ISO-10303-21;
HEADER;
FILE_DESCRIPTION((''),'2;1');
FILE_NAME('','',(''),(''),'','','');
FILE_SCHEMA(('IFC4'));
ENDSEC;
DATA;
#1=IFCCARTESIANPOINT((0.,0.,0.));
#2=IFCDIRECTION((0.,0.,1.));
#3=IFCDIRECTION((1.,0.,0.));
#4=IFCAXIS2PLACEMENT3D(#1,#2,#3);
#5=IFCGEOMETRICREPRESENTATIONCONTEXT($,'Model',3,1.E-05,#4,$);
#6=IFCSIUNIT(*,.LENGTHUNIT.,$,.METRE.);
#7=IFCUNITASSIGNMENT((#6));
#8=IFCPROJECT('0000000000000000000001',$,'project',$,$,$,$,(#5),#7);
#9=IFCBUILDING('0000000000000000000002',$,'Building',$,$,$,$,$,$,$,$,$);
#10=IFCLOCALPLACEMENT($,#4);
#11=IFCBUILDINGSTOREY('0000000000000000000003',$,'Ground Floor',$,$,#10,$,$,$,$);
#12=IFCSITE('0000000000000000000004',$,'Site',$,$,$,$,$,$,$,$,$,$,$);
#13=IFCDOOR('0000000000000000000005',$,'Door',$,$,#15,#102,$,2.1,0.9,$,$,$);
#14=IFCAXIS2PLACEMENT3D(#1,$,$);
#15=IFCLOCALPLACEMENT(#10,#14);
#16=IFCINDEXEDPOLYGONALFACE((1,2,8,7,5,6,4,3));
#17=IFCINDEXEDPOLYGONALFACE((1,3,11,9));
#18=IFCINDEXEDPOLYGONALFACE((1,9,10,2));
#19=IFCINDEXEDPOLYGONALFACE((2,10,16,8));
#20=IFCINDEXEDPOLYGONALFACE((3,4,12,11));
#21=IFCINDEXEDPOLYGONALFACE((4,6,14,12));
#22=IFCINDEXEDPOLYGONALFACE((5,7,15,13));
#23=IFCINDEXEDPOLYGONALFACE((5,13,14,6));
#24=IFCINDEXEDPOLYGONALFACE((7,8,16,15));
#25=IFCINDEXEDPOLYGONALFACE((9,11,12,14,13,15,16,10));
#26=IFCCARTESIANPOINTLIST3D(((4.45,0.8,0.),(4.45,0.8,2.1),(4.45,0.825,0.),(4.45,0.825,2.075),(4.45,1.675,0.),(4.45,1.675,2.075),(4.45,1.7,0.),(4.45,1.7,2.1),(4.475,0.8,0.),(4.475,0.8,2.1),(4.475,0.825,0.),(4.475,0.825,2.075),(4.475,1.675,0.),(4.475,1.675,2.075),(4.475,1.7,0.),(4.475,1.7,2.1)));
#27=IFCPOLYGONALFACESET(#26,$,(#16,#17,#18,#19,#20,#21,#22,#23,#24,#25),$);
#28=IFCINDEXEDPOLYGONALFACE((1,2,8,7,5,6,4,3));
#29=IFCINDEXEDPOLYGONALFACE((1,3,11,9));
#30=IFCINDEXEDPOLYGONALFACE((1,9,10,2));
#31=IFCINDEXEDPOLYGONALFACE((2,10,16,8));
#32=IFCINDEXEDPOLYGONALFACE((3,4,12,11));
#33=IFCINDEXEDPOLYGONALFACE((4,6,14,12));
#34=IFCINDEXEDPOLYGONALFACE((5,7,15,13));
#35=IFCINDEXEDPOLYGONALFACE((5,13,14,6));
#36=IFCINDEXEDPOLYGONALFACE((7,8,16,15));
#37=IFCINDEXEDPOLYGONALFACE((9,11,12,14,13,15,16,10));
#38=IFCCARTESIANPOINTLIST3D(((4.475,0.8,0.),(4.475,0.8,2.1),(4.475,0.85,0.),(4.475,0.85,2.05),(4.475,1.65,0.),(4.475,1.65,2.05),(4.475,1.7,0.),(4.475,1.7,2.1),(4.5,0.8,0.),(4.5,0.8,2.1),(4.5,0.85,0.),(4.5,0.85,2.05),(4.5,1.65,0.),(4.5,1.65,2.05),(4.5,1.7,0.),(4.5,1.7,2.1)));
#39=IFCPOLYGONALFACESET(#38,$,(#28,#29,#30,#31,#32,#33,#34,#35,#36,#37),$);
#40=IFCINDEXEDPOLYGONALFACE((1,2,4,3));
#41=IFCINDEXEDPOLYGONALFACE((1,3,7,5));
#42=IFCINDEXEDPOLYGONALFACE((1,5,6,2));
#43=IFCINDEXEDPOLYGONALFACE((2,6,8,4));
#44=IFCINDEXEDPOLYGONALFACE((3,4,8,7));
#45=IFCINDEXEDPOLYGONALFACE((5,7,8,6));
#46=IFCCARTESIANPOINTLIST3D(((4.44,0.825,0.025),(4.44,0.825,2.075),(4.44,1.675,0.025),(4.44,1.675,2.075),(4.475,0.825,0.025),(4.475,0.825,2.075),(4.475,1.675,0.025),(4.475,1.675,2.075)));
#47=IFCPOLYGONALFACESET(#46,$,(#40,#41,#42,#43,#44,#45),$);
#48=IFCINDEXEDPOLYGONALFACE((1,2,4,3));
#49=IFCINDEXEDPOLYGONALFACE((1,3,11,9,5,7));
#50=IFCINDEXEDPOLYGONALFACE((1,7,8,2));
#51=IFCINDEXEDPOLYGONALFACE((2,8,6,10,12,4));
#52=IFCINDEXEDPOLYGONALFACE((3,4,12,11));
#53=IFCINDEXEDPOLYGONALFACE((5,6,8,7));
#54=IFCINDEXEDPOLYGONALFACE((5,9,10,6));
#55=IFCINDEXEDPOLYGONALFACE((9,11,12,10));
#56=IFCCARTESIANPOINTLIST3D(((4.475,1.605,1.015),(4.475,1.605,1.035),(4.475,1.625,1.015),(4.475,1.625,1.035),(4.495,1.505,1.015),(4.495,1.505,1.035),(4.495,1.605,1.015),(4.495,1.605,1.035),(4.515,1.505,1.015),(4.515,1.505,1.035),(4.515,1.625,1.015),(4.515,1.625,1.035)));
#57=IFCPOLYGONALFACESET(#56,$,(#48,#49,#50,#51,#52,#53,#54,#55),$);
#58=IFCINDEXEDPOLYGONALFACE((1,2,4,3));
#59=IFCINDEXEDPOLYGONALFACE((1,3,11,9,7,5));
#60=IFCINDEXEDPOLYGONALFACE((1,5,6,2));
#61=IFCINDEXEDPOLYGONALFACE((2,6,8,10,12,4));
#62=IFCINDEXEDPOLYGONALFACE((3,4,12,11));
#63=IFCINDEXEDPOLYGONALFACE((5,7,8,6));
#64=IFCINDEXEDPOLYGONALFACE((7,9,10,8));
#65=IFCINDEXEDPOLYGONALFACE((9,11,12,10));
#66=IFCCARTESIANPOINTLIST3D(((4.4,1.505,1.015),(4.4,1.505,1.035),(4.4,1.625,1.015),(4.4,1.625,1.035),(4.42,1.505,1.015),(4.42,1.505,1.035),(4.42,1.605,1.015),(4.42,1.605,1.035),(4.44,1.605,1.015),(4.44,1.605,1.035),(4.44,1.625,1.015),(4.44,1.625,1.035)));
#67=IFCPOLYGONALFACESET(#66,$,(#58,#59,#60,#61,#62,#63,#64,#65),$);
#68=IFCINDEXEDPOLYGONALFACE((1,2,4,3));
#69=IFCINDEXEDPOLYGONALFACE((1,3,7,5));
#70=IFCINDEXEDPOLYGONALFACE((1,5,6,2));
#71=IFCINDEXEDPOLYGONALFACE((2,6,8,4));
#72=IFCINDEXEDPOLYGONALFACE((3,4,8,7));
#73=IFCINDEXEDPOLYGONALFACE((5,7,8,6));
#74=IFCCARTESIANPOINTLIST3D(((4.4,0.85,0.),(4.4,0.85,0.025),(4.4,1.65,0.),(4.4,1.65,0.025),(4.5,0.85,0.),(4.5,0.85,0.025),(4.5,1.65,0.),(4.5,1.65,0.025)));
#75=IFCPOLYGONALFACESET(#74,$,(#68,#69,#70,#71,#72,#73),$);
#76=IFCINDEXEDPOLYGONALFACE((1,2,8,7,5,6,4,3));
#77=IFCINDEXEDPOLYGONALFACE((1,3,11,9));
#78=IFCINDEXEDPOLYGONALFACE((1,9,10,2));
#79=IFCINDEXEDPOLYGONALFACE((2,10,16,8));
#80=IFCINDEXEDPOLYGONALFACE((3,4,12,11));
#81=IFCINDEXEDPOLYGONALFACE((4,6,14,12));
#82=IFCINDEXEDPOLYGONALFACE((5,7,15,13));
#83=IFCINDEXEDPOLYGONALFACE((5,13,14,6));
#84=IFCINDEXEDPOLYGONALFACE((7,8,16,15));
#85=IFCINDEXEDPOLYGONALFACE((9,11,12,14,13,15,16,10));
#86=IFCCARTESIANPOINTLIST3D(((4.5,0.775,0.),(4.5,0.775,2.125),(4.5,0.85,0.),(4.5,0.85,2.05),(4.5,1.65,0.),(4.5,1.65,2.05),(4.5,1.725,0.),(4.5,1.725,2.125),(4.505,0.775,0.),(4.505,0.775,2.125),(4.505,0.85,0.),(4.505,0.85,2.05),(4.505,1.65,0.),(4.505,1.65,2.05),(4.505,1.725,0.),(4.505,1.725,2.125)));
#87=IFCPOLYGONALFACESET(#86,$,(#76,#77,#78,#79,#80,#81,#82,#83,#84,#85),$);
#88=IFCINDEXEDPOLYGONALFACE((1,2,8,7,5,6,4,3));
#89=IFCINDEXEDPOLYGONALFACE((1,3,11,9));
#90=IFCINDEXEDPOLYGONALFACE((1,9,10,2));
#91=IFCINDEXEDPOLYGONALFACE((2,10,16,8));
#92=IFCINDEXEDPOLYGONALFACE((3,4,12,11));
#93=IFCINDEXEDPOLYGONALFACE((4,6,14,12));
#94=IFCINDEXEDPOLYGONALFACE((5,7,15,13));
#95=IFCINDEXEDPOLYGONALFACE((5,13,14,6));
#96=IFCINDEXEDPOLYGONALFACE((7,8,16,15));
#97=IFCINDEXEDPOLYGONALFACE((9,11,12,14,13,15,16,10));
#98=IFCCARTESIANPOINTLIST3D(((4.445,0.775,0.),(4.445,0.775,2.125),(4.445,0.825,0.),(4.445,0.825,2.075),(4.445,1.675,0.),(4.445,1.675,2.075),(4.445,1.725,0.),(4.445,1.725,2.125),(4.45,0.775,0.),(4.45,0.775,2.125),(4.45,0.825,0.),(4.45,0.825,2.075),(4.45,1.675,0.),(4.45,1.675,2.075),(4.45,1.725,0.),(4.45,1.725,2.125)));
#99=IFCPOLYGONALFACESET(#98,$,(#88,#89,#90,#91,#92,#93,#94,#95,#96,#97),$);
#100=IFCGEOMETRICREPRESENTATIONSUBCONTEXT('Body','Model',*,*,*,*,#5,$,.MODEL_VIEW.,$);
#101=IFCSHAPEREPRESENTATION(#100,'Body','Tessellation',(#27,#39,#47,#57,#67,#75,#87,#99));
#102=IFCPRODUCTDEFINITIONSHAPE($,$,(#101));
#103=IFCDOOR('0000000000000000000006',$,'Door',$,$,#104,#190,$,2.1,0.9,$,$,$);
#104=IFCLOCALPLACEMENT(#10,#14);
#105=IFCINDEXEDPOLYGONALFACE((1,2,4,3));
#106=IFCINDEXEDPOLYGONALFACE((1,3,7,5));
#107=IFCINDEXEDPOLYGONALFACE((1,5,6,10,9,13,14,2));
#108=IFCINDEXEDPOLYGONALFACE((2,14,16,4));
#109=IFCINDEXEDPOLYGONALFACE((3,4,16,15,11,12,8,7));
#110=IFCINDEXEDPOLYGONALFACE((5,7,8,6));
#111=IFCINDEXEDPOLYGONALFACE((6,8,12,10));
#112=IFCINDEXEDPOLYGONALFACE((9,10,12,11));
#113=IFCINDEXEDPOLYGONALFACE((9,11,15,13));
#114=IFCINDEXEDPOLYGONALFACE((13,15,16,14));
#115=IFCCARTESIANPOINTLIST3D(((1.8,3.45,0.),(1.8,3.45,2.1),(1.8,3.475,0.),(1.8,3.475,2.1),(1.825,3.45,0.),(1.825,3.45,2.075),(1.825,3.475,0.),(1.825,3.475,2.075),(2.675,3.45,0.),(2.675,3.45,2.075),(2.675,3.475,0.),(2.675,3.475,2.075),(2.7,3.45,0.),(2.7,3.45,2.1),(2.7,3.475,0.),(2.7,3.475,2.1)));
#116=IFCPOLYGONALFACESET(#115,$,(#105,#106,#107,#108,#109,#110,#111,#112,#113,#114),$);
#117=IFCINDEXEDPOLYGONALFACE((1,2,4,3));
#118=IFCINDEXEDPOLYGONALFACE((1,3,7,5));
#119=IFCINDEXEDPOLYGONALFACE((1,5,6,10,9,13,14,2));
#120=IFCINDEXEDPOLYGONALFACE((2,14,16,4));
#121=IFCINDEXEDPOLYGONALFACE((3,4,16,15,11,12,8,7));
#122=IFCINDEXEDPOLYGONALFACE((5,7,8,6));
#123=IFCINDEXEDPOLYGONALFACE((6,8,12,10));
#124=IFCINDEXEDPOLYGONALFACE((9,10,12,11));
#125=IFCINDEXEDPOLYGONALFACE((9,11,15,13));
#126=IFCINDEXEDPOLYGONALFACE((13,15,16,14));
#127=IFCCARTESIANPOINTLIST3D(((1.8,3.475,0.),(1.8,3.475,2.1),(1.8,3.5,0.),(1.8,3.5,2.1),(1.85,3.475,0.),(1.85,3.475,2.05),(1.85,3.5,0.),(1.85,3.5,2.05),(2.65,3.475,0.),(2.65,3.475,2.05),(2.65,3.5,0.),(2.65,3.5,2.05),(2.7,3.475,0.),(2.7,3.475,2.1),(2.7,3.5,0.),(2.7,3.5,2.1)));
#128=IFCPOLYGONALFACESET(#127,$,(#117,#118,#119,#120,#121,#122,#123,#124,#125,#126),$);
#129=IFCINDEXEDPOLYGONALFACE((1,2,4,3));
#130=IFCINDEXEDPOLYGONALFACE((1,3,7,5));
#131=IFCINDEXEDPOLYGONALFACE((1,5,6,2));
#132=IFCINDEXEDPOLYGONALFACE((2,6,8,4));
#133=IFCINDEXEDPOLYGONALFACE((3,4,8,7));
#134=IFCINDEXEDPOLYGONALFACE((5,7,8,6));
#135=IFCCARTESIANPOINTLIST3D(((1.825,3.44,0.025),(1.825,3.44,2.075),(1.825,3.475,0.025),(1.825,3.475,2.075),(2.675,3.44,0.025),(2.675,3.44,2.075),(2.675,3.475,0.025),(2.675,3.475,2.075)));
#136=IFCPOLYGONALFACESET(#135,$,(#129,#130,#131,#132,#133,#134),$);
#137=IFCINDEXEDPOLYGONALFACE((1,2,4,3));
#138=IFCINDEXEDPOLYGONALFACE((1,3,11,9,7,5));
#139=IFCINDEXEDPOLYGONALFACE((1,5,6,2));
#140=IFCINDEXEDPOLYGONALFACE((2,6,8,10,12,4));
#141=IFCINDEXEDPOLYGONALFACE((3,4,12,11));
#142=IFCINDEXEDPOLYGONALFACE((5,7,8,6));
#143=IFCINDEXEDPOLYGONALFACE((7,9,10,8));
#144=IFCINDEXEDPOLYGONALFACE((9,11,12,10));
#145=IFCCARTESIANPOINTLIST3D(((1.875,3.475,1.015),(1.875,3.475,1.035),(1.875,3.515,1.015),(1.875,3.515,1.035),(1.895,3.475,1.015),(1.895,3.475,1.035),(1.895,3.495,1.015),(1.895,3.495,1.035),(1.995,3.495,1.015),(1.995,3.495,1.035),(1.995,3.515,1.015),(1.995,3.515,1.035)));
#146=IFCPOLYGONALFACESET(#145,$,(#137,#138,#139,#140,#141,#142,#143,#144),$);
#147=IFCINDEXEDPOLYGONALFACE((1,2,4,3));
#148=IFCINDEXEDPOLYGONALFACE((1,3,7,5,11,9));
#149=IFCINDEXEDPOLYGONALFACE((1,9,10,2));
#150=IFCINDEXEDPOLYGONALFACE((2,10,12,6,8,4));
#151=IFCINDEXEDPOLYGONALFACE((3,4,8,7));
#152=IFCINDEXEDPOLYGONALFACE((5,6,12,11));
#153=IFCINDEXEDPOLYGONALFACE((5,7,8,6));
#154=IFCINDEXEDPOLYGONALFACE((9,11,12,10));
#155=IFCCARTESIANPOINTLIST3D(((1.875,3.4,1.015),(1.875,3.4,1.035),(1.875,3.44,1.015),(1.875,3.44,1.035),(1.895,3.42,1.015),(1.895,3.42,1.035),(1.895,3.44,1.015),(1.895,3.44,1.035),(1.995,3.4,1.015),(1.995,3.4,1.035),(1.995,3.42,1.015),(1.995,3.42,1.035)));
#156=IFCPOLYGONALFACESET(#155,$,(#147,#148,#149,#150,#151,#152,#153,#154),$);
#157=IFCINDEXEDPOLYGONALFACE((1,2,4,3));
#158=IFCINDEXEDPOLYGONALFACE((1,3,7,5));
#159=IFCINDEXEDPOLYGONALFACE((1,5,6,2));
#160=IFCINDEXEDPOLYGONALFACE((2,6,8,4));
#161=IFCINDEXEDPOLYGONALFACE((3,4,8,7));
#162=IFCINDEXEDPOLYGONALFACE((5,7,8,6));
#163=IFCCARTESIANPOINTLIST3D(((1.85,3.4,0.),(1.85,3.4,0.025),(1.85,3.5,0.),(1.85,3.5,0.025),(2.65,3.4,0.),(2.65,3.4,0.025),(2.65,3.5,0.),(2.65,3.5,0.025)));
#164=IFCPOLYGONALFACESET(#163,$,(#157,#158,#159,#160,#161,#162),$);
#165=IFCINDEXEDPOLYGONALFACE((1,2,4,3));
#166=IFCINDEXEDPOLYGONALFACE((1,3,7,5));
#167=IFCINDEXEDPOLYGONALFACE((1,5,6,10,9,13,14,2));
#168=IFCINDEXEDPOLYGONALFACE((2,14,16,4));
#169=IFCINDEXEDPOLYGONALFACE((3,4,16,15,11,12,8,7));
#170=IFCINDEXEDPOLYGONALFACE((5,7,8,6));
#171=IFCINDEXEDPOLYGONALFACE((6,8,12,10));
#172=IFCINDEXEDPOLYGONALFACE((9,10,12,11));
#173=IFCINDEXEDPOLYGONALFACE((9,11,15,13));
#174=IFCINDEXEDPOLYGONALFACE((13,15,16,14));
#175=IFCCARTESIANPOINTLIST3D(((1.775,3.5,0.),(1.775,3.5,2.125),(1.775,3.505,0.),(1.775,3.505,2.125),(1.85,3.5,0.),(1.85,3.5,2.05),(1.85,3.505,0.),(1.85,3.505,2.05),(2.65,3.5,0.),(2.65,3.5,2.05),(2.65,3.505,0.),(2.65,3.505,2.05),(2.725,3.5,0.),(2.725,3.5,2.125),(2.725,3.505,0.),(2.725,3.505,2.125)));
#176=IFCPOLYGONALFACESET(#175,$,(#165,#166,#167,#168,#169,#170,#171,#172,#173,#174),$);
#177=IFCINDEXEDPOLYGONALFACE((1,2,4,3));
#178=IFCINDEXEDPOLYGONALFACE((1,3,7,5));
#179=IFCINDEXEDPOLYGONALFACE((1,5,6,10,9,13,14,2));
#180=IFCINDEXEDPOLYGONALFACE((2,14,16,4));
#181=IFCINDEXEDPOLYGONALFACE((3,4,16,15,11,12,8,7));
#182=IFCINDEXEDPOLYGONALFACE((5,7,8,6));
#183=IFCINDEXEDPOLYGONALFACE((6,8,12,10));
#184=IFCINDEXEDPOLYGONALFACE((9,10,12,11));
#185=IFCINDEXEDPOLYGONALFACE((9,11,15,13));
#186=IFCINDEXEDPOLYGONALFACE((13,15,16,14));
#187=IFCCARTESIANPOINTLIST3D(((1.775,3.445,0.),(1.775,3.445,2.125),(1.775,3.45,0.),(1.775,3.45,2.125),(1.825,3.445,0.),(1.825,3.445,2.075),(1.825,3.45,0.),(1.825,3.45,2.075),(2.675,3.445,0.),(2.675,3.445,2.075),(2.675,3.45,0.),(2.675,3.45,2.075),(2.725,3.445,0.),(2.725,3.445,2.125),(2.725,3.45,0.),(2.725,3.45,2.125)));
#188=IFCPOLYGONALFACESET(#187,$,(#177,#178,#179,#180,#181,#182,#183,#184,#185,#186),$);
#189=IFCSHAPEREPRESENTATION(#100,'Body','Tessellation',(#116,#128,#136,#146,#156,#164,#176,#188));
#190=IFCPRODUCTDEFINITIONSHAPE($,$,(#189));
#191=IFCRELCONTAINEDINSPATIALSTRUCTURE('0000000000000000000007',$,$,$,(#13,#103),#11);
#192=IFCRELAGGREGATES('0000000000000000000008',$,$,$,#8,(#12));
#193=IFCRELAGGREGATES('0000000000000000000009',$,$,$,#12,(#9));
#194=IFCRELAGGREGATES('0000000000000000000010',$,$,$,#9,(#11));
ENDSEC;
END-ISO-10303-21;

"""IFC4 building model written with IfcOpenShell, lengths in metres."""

from ifc_helpers import new_model, si_unit, frame, origin_with_axes, place, context, subcontext, project, spatial, line, indexed_curve, outline, extrude, element, save


model = new_model("IFC4")

# Units and contexts
model_context = context("Model", 3, precision=1e-05, world=origin_with_axes())
body_context = subcontext(model_context, "Body", "Model", "MODEL_VIEW")
ifc_project = project(units=[si_unit("LENGTHUNIT", "METRE")], contexts=[model_context])

# Site, building, storey
site = spatial("IfcSite", under=ifc_project, Name="Site")
building = spatial("IfcBuilding", under=site, Name="Building")
storey_placement = place(None, origin_with_axes())
storey = spatial("IfcBuildingStorey", under=building, at=storey_placement, Name="Ground Floor")

# Doors
door_1_placement = place(storey_placement, frame((4.5, 0.8, 0.0), z_axis=(0.0, 0.0, 1.0), x_axis=(0.0, 1.0, 0.0)))
element("IfcDoor", 1, at=door_1_placement, inside=storey, Name="Door", OverallHeight=2.1, OverallWidth=0.9, context=body_context, shape_type="SweptSolid", body=[
    extrude(outline(indexed_curve([(0.0, 0.0), (0.0, 2.1), (0.9, 2.1), (0.9, 0.0), (0.875, 0.0), (0.875, 2.075), (0.025, 2.075), (0.025, 0.0)], segments=[line(1, 2, 3, 4, 5, 6, 7, 8, 1)])), frame((0.0, 0.025, 0.0), z_axis=(0.0, -1.0, 0.0), x_axis=(1.0, 0.0, 0.0)), (0.0, 0.0, -1.0), 0.025),
    extrude(outline(indexed_curve([(0.0, 0.0), (0.0, 2.1), (0.9, 2.1), (0.9, 0.0), (0.85, 0.0), (0.85, 2.05), (0.05, 2.05), (0.05, 0.0)], segments=[line(1, 2, 3, 4, 5, 6, 7, 8, 1)])), frame((0.0, 0.0, 0.0), z_axis=(0.0, -1.0, 0.0), x_axis=(1.0, 0.0, 0.0)), (0.0, 0.0, -1.0), 0.025),
    extrude(outline(indexed_curve([(0.0, 0.0), (0.85, 0.0), (0.85, 0.035), (0.0, 0.035)], segments=[line(1, 2, 3, 4, 1)])), frame((0.025, 0.025, 0.025), z_axis=(0.0, 0.0, 1.0), x_axis=(1.0, 0.0, 0.0)), (0.0, 0.0, 1.0), 2.05),
    extrude(outline(indexed_curve([(0.0, 0.0), (0.0, -0.04), (-0.12, -0.04), (-0.12, -0.02), (-0.02, -0.02), (-0.02, 0.0)], segments=[line(1, 2, 3, 4, 5, 6, 1)])), frame((0.825, 0.025, 1.015), z_axis=(0.0, 0.0, 1.0), x_axis=(1.0, 0.0, 0.0)), (0.0, 0.0, 1.0), 0.02),
    extrude(outline(indexed_curve([(0.0, 0.0), (0.0, 0.04), (-0.12, 0.04), (-0.12, 0.02), (-0.02, 0.02), (-0.02, 0.0)], segments=[line(1, 2, 3, 4, 5, 6, 1)])), frame((0.825, 0.06, 1.015), z_axis=(0.0, 0.0, 1.0), x_axis=(1.0, 0.0, 0.0)), (0.0, 0.0, 1.0), 0.02),
    extrude(outline(indexed_curve([(0.0, 0.0), (0.8, 0.0), (0.8, 0.1), (0.0, 0.1)], segments=[line(1, 2, 3, 4, 1)])), frame((0.05, 0.0, 0.0), z_axis=(0.0, 0.0, 1.0), x_axis=(1.0, 0.0, 0.0)), (0.0, 0.0, 1.0), 0.025),
    extrude(outline(indexed_curve([(0.0, 0.0), (0.0, 2.125), (0.95, 2.125), (0.95, 0.0), (0.875, 0.0), (0.875, 2.05), (0.075, 2.05), (0.075, 0.0)], segments=[line(1, 2, 3, 4, 5, 6, 7, 8, 1)])), frame((-0.025, -0.005, 0.0), z_axis=(0.0, -1.0, 0.0), x_axis=(1.0, 0.0, 0.0)), (0.0, 0.0, -1.0), 0.005),
    extrude(outline(indexed_curve([(0.0, 0.0), (0.0, 2.125), (0.95, 2.125), (0.95, 0.0), (0.9, 0.0), (0.9, 2.075), (0.05, 2.075), (0.05, 0.0)], segments=[line(1, 2, 3, 4, 5, 6, 7, 8, 1)])), frame((-0.025, 0.05, 0.0), z_axis=(0.0, -1.0, 0.0), x_axis=(1.0, 0.0, 0.0)), (0.0, 0.0, -1.0), 0.005),
])
door_2_placement = place(storey_placement, frame((2.7, 3.5, 0.0), z_axis=(0.0, 0.0, 1.0), x_axis=(-1.0, 0.0, 0.0)))
element("IfcDoor", 2, at=door_2_placement, inside=storey, Name="Door", OverallHeight=2.1, OverallWidth=0.9, context=body_context, shape_type="SweptSolid", body=[
    extrude(outline(indexed_curve([(0.0, 0.0), (0.0, 2.1), (0.9, 2.1), (0.9, 0.0), (0.875, 0.0), (0.875, 2.075), (0.025, 2.075), (0.025, 0.0)], segments=[line(1, 2, 3, 4, 5, 6, 7, 8, 1)])), frame((0.0, 0.025, 0.0), z_axis=(0.0, -1.0, 0.0), x_axis=(1.0, 0.0, 0.0)), (0.0, 0.0, -1.0), 0.025),
    extrude(outline(indexed_curve([(0.0, 0.0), (0.0, 2.1), (0.9, 2.1), (0.9, 0.0), (0.85, 0.0), (0.85, 2.05), (0.05, 2.05), (0.05, 0.0)], segments=[line(1, 2, 3, 4, 5, 6, 7, 8, 1)])), frame((0.0, 0.0, 0.0), z_axis=(0.0, -1.0, 0.0), x_axis=(1.0, 0.0, 0.0)), (0.0, 0.0, -1.0), 0.025),
    extrude(outline(indexed_curve([(0.0, 0.0), (0.85, 0.0), (0.85, 0.035), (0.0, 0.035)], segments=[line(1, 2, 3, 4, 1)])), frame((0.025, 0.025, 0.025), z_axis=(0.0, 0.0, 1.0), x_axis=(1.0, 0.0, 0.0)), (0.0, 0.0, 1.0), 2.05),
    extrude(outline(indexed_curve([(0.0, 0.0), (0.0, -0.04), (-0.12, -0.04), (-0.12, -0.02), (-0.02, -0.02), (-0.02, 0.0)], segments=[line(1, 2, 3, 4, 5, 6, 1)])), frame((0.825, 0.025, 1.015), z_axis=(0.0, 0.0, 1.0), x_axis=(1.0, 0.0, 0.0)), (0.0, 0.0, 1.0), 0.02),
    extrude(outline(indexed_curve([(0.0, 0.0), (0.0, 0.04), (-0.12, 0.04), (-0.12, 0.02), (-0.02, 0.02), (-0.02, 0.0)], segments=[line(1, 2, 3, 4, 5, 6, 1)])), frame((0.825, 0.06, 1.015), z_axis=(0.0, 0.0, 1.0), x_axis=(1.0, 0.0, 0.0)), (0.0, 0.0, 1.0), 0.02),
    extrude(outline(indexed_curve([(0.0, 0.0), (0.8, 0.0), (0.8, 0.1), (0.0, 0.1)], segments=[line(1, 2, 3, 4, 1)])), frame((0.05, 0.0, 0.0), z_axis=(0.0, 0.0, 1.0), x_axis=(1.0, 0.0, 0.0)), (0.0, 0.0, 1.0), 0.025),
    extrude(outline(indexed_curve([(0.0, 0.0), (0.0, 2.125), (0.95, 2.125), (0.95, 0.0), (0.875, 0.0), (0.875, 2.05), (0.075, 2.05), (0.075, 0.0)], segments=[line(1, 2, 3, 4, 5, 6, 7, 8, 1)])), frame((-0.025, -0.005, 0.0), z_axis=(0.0, -1.0, 0.0), x_axis=(1.0, 0.0, 0.0)), (0.0, 0.0, -1.0), 0.005),
    extrude(outline(indexed_curve([(0.0, 0.0), (0.0, 2.125), (0.95, 2.125), (0.95, 0.0), (0.9, 0.0), (0.9, 2.075), (0.05, 2.075), (0.05, 0.0)], segments=[line(1, 2, 3, 4, 5, 6, 7, 8, 1)])), frame((-0.025, 0.05, 0.0), z_axis=(0.0, -1.0, 0.0), x_axis=(1.0, 0.0, 0.0)), (0.0, 0.0, -1.0), 0.005),
])

save(model, "model.ifc")
